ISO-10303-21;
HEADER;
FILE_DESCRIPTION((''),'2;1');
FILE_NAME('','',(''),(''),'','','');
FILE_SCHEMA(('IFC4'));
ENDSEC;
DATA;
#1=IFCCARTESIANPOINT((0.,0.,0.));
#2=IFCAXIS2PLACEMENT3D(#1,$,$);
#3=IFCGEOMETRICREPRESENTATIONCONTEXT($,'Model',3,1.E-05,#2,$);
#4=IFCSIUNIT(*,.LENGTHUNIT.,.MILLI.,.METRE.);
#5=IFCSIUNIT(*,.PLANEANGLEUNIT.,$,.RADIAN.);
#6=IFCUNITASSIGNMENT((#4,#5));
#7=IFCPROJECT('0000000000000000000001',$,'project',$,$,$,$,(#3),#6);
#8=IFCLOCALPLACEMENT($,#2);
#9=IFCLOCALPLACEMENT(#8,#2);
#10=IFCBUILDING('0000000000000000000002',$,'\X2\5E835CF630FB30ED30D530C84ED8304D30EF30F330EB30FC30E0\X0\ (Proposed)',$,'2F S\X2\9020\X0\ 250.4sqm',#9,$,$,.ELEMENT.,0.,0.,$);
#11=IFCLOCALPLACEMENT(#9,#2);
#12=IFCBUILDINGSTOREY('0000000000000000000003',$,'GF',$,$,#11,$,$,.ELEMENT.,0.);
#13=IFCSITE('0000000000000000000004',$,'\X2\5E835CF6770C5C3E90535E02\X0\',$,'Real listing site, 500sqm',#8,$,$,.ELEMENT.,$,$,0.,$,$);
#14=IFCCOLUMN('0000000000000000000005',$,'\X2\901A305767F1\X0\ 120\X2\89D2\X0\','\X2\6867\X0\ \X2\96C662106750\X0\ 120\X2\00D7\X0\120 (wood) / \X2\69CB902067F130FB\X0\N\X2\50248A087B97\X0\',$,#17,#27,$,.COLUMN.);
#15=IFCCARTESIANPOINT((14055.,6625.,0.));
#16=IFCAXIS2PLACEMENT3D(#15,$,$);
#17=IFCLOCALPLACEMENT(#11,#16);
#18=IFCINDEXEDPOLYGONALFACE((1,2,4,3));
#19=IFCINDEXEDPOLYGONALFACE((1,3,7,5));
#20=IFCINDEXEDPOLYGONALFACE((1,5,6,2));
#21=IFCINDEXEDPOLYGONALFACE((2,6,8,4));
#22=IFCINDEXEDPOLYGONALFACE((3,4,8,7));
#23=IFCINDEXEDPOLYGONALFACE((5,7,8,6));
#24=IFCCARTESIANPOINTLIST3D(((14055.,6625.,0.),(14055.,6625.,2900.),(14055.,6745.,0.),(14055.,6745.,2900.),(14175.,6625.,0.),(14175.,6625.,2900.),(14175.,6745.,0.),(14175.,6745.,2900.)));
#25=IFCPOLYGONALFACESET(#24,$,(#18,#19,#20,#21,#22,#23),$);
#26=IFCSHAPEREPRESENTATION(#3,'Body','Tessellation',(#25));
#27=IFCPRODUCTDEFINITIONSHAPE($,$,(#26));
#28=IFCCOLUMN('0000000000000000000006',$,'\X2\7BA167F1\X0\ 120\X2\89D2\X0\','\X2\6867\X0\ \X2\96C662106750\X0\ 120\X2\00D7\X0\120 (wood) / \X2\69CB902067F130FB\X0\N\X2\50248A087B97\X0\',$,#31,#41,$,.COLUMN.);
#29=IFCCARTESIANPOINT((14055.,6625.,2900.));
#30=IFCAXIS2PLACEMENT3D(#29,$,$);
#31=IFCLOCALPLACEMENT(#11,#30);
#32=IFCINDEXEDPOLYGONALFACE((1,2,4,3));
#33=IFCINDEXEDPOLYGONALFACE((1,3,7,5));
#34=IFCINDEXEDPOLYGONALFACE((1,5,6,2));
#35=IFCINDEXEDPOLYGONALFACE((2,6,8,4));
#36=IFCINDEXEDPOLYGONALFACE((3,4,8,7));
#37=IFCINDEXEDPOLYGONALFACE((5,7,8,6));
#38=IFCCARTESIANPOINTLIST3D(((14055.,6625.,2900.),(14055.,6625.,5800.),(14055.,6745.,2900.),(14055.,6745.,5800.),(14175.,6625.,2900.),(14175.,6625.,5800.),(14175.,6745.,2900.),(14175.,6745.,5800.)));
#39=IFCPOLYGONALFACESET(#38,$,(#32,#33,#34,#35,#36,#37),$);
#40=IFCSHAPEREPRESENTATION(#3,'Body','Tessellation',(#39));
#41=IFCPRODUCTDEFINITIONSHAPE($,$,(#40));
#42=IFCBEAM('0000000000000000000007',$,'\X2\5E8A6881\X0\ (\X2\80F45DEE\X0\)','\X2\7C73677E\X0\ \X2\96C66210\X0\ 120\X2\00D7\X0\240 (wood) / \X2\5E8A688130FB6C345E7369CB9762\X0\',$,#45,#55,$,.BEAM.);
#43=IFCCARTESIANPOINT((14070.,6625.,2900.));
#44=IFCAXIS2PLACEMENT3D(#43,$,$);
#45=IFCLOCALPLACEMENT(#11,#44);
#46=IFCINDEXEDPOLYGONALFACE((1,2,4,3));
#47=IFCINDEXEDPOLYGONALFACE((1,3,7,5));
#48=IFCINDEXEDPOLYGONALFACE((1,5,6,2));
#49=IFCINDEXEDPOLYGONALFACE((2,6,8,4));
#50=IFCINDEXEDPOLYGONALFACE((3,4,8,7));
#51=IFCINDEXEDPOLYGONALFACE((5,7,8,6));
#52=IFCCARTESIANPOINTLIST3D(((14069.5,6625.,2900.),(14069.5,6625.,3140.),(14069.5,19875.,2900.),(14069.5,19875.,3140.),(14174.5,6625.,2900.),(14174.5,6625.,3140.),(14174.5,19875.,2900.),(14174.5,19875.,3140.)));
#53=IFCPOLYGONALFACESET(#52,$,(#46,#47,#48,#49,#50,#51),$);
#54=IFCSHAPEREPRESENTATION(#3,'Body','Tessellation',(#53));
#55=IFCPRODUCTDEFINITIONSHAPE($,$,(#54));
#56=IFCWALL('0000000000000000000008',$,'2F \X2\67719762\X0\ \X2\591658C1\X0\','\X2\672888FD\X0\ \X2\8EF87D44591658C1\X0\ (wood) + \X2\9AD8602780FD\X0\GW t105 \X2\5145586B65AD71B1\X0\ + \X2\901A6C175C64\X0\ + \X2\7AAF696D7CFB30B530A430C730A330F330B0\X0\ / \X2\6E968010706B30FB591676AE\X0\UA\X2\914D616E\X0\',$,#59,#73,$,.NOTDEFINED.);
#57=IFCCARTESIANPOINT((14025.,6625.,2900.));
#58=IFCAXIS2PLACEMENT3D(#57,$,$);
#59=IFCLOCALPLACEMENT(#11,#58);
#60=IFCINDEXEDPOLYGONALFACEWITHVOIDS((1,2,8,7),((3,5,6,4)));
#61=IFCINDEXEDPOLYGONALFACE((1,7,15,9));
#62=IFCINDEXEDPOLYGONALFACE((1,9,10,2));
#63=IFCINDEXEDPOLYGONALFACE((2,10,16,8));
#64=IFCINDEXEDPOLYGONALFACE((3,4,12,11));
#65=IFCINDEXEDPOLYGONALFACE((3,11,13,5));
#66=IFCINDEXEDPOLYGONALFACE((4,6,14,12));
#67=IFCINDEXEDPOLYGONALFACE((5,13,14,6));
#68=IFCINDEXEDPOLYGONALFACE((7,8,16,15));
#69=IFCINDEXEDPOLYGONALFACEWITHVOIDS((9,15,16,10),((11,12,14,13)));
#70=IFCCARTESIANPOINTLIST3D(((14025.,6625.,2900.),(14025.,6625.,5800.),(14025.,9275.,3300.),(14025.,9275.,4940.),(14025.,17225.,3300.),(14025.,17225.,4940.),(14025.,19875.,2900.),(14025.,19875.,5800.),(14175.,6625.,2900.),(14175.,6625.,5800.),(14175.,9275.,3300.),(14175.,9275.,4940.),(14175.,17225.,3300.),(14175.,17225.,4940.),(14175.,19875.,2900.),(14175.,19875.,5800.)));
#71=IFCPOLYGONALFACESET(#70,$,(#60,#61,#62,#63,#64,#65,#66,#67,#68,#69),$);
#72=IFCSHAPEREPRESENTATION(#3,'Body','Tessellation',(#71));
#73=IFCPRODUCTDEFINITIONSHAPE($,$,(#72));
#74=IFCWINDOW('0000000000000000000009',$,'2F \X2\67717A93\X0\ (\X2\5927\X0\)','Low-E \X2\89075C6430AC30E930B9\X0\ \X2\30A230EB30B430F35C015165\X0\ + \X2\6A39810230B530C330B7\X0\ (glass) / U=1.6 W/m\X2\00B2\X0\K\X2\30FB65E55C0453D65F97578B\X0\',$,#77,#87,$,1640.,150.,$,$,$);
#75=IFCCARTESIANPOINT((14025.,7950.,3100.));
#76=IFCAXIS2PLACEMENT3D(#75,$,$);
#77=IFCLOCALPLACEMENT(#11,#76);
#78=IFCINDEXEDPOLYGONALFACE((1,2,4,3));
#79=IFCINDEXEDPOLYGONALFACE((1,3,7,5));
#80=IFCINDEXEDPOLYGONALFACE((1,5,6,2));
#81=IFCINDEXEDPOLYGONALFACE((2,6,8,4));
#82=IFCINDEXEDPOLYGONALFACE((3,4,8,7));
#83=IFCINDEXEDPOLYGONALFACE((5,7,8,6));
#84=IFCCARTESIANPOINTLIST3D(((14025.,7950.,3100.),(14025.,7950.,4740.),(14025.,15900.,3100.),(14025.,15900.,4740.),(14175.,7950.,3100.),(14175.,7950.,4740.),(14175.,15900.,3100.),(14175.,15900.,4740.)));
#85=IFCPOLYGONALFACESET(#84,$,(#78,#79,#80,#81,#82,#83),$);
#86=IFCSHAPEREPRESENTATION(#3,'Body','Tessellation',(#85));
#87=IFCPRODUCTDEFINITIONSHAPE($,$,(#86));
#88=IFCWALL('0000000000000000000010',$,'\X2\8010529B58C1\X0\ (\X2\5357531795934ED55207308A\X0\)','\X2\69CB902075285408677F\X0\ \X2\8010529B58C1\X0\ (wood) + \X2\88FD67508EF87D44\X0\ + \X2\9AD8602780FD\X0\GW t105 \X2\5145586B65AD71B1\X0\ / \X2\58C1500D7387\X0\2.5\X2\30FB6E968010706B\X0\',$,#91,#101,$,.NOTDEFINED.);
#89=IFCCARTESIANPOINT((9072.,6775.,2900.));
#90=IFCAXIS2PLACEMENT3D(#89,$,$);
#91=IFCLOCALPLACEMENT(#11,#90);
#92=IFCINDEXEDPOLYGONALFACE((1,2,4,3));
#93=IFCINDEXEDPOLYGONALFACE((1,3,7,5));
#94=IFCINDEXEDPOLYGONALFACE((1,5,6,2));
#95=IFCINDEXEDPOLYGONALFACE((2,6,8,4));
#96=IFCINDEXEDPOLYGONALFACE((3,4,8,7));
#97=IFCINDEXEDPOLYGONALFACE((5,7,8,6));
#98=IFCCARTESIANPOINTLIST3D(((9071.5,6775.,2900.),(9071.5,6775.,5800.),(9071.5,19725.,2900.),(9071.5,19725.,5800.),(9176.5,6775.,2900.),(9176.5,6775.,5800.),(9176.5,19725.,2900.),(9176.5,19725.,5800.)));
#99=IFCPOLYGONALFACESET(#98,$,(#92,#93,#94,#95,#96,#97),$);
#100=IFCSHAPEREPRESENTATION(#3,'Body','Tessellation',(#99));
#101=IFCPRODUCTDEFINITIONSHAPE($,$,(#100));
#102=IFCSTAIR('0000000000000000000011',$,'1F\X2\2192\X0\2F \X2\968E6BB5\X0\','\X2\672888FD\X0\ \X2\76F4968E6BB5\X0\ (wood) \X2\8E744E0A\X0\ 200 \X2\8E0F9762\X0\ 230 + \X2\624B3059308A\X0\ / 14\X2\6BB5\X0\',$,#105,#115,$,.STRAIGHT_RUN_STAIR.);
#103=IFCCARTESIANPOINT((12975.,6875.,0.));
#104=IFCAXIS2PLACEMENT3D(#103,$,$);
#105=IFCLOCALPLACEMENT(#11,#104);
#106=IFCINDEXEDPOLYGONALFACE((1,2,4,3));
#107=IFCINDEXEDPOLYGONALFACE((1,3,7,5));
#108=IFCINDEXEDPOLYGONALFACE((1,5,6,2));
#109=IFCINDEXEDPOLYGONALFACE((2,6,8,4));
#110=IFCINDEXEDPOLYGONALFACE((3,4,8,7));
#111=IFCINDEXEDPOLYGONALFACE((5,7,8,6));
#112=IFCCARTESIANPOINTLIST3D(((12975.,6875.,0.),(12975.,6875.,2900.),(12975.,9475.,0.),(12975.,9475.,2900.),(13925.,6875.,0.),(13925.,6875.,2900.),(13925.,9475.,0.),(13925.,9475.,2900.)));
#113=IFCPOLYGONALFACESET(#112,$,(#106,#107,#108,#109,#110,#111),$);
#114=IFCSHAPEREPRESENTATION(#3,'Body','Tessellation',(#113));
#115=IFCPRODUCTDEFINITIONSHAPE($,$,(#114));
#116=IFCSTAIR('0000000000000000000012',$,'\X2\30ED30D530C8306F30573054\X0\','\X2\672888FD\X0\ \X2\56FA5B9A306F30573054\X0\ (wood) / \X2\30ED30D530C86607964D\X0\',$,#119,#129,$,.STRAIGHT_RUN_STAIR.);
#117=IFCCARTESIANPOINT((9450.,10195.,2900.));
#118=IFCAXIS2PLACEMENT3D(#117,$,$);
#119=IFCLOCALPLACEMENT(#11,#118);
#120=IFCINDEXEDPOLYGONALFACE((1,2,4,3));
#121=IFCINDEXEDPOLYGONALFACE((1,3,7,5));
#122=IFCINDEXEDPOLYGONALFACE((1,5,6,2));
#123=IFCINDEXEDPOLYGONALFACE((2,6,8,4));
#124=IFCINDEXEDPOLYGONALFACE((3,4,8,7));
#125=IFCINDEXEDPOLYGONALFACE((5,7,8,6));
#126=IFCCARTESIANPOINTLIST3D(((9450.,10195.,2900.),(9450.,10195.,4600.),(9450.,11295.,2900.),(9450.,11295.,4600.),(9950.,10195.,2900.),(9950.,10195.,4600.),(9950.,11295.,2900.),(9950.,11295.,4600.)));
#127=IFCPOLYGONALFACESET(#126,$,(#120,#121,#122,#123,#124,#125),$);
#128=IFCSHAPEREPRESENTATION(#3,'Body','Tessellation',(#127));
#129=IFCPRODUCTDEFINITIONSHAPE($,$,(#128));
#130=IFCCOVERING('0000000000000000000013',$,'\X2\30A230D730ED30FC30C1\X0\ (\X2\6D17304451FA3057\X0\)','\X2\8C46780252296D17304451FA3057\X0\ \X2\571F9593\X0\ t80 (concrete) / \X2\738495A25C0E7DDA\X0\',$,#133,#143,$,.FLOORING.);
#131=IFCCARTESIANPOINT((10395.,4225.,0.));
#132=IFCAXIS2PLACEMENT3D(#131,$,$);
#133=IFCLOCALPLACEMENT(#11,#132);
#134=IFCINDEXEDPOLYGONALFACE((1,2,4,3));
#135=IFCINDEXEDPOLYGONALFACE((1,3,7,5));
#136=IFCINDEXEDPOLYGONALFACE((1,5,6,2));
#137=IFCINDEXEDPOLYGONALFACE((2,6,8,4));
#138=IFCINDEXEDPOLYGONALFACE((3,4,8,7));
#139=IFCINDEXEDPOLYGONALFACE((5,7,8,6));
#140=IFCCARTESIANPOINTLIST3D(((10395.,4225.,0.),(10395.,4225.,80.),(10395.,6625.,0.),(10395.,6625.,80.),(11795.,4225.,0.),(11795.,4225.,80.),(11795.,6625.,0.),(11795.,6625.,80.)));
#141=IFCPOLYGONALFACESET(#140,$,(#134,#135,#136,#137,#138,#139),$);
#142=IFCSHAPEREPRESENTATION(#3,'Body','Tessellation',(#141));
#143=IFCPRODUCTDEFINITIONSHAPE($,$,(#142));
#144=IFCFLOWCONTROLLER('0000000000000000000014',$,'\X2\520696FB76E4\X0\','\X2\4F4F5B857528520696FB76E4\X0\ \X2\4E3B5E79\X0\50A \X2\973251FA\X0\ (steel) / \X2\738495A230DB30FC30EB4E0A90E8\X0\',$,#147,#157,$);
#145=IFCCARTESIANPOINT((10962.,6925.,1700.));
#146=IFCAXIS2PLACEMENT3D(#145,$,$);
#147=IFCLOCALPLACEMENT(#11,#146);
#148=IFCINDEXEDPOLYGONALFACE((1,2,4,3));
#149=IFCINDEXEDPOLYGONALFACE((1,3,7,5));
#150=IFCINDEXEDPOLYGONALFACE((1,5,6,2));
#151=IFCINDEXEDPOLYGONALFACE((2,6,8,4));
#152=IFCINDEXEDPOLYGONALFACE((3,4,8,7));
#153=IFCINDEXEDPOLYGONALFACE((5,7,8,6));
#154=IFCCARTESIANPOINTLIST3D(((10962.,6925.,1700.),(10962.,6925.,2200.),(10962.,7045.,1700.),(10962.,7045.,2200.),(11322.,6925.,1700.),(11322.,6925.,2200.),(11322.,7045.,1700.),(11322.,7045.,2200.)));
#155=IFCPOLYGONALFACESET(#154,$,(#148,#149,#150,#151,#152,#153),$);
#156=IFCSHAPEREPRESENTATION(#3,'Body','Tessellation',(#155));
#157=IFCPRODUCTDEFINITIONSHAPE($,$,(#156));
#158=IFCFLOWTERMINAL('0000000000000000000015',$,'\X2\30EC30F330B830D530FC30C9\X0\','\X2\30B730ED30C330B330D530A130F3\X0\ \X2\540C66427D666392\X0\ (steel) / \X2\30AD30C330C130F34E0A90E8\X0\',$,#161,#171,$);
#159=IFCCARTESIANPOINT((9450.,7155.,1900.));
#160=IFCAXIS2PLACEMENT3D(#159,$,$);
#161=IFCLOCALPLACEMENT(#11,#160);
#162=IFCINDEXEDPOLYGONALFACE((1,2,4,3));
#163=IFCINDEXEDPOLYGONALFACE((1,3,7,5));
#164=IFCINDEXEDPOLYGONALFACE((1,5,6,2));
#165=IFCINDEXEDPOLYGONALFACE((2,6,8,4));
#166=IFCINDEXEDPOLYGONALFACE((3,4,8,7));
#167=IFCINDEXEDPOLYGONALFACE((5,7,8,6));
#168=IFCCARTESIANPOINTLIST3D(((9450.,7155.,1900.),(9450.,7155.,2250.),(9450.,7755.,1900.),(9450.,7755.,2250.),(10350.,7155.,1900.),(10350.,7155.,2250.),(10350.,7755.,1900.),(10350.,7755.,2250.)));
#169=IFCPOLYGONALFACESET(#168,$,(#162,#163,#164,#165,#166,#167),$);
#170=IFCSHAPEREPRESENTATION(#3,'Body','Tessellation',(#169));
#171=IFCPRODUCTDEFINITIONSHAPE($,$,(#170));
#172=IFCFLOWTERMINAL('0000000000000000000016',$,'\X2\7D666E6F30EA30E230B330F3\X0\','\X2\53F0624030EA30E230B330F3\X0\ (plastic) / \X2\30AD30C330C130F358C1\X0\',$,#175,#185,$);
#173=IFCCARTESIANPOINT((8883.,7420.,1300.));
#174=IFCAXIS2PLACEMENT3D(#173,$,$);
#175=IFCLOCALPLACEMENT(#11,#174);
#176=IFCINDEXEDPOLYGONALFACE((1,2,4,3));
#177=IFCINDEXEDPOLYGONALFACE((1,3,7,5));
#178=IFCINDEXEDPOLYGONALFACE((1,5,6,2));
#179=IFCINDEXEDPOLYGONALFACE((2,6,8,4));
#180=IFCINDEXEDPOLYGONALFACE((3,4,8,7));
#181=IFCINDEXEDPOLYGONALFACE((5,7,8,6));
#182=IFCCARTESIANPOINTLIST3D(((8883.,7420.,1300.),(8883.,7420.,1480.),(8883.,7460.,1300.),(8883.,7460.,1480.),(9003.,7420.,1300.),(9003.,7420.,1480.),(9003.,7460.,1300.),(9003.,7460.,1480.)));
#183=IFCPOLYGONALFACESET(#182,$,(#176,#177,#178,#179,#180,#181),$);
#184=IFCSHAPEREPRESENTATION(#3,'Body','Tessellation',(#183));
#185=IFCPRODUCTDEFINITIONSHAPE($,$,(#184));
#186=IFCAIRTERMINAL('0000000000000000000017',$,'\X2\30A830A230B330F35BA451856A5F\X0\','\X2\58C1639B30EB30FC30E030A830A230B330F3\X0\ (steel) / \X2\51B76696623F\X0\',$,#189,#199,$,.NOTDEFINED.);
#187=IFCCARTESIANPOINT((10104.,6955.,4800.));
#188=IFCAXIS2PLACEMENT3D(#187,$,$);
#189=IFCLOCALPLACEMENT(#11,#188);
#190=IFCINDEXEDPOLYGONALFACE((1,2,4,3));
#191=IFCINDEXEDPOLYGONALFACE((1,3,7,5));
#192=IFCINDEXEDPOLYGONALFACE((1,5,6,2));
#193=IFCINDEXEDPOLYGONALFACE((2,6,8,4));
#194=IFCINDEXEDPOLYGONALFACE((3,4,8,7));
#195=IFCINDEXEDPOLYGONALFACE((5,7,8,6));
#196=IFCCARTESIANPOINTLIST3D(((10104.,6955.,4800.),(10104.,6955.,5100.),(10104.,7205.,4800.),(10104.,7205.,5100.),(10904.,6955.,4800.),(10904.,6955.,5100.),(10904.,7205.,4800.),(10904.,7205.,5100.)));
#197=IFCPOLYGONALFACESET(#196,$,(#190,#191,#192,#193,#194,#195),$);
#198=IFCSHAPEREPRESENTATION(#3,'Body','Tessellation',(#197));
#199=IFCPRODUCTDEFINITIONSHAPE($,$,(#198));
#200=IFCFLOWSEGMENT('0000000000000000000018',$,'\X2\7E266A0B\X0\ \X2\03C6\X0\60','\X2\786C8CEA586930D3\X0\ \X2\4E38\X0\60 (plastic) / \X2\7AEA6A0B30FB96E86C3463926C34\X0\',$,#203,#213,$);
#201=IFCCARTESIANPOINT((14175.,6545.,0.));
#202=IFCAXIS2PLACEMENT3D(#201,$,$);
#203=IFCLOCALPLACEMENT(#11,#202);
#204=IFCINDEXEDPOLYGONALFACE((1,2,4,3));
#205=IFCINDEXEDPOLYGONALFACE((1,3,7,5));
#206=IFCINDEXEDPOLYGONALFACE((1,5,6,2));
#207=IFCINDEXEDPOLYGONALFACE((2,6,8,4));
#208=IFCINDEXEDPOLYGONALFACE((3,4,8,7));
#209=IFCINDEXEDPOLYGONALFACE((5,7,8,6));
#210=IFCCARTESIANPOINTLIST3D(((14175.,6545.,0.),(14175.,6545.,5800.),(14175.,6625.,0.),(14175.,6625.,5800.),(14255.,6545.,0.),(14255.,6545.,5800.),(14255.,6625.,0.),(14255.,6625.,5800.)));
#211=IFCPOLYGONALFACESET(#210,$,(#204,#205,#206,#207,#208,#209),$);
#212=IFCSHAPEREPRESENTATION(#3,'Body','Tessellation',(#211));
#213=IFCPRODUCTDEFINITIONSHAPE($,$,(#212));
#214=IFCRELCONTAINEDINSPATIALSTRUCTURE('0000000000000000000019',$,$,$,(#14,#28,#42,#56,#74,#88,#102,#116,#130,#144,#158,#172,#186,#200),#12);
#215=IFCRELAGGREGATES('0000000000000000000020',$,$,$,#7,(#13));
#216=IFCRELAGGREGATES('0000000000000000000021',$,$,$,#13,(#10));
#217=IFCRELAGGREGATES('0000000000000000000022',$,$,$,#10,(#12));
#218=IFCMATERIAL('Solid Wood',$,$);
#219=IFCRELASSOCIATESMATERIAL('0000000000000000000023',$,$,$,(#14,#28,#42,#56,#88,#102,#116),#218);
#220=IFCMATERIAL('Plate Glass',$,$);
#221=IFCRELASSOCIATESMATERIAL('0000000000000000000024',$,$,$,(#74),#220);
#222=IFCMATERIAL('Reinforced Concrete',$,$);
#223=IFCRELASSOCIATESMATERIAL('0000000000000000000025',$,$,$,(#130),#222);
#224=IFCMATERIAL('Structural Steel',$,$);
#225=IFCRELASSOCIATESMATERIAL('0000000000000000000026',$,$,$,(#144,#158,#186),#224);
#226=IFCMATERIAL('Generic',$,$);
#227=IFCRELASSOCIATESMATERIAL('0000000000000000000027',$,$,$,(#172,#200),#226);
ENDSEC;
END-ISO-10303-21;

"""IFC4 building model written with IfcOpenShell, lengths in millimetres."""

from ifc_helpers import new_model, si_unit, frame, frame_2d, origin, place, context, project, spatial, rectangle, extrude, material, element, fill, save


model = new_model("IFC4")

# Units and contexts
model_context = context("Model", 3, precision=1e-05, world=origin())
ifc_project = project(units=[si_unit("LENGTHUNIT", "METRE", prefix="MILLI"), si_unit("PLANEANGLEUNIT", "RADIAN")], contexts=[model_context])

# Site, building, storey
site_placement = place(None, origin())
site = spatial("IfcSite", under=ifc_project, at=site_placement, Name="広島県尾道市", ObjectType="Real listing site, 500sqm", CompositionType="ELEMENT", RefElevation=0.0)
building_placement = place(site_placement, origin())
building = spatial("IfcBuilding", under=site, at=building_placement, Name="広島・ロフト付きワンルーム (Proposed)", ObjectType="2F S造 250.4sqm", CompositionType="ELEMENT", ElevationOfRefHeight=0.0, ElevationOfTerrain=0.0)
storey_placement = place(building_placement, origin())
storey = spatial("IfcBuildingStorey", under=building, at=storey_placement, Name="GF", CompositionType="ELEMENT", Elevation=0.0)

# Columns
ifc_material_1 = material(Name="Solid Wood")
column_1_placement = place(storey_placement, frame((14055.0, 6625.0, 0.0)))
element("IfcColumn", 1, at=column_1_placement, inside=storey, material=ifc_material_1, Name="通し柱 120角", Description="桧 集成材 120×120 (wood) / 構造柱・N値計算", PredefinedType="COLUMN", context=model_context, shape_type="SweptSolid", body=[
    extrude(rectangle(XDim=120.0, YDim=120.0, at=frame_2d((60.0, 60.0))), frame((14055.0, 6625.0, 0.0)), (0.0, 0.0, 1.0), 2900.0),
])
column_2_placement = place(storey_placement, frame((14055.0, 6625.0, 2900.0)))
element("IfcColumn", 2, at=column_2_placement, inside=storey, material=ifc_material_1, Name="管柱 120角", Description="桧 集成材 120×120 (wood) / 構造柱・N値計算", PredefinedType="COLUMN", context=model_context, shape_type="SweptSolid", body=[
    extrude(rectangle(XDim=120.0, YDim=120.0, at=frame_2d((60.0, 60.0))), frame((14055.0, 6625.0, 2900.0)), (0.0, 0.0, 1.0), 2900.0),
])

# Beam
beam_1_placement = place(storey_placement, frame((14070.0, 6625.0, 2900.0)))
element("IfcBeam", 3, at=beam_1_placement, inside=storey, material=ifc_material_1, Name="床梁 (胴差)", Description="米松 集成 120×240 (wood) / 床梁・水平構面", PredefinedType="BEAM", context=model_context, shape_type="SweptSolid", body=[
    extrude(rectangle(XDim=105.0, YDim=13250.0, at=frame_2d((52.0, 6625.0))), frame((14070.0, 6625.0, 2900.0)), (0.0, 0.0, 1.0), 240.0),
])

# Shared definitions
ifc_material_2 = material(Name="Plate Glass")

# Wall, opening, window
wall_1_placement = place(storey_placement, frame((14025.0, 6625.0, 2900.0)))
wall_1 = element("IfcWall", 4, at=wall_1_placement, inside=storey, material=ifc_material_1, Name="2F 東面 外壁", Description="木製 軸組外壁 (wood) + 高性能GW t105 充填断熱 + 通気層 + 窯業系サイディング / 準耐火・外皮UA配慮", PredefinedType="NOTDEFINED", context=model_context, shape_type="SweptSolid", body=[
    extrude(rectangle(XDim=150.0, YDim=13250.0, at=frame_2d((75.0, 6625.0))), frame((14025.0, 6625.0, 2900.0)), (0.0, 0.0, 1.0), 2900.0),
])
opening_1_placement = place(storey_placement, frame((14025.0, 7950.0, 3100.0)))
opening_1 = element("IfcOpeningElement", 5, at=opening_1_placement, cuts=wall_1, PredefinedType="NOTDEFINED", context=model_context, shape_type="SweptSolid", body=[
    extrude(rectangle(XDim=150.0, YDim=7950.0, at=frame_2d((75.0, 3975.0))), frame((14025.0, 7950.0, 3100.0)), (0.0, 0.0, 1.0), 1640.0),
])
window_1_placement = place(storey_placement, frame((14025.0, 7950.0, 3100.0)))
window_1 = element("IfcWindow", 6, at=window_1_placement, inside=storey, material=ifc_material_2, Name="2F 東窓 (大)", Description="Low-E 複層ガラス アルゴン封入 + 樹脂サッシ (glass) / U=1.6 W/m²K・日射取得型", OverallHeight=1640.0, OverallWidth=150.0, context=model_context, shape_type="SweptSolid", body=[
    extrude(rectangle(XDim=150.0, YDim=7950.0, at=frame_2d((75.0, 3975.0))), frame((14025.0, 7950.0, 3100.0)), (0.0, 0.0, 1.0), 1640.0),
])
fill(opening_1, window_1)

# Wall
wall_2_placement = place(storey_placement, frame((9072.0, 6775.0, 2900.0)))
element("IfcWall", 7, at=wall_2_placement, inside=storey, material=ifc_material_1, Name="耐力壁 (南北間仕切り)", Description="構造用合板 耐力壁 (wood) + 製材軸組 + 高性能GW t105 充填断熱 / 壁倍率2.5・準耐火", PredefinedType="NOTDEFINED", context=model_context, shape_type="SweptSolid", body=[
    extrude(rectangle(XDim=105.0, YDim=12950.0, at=frame_2d((52.0, 6475.0))), frame((9072.0, 6775.0, 2900.0)), (0.0, 0.0, 1.0), 2900.0),
])

# Stairs
stair_1_placement = place(storey_placement, frame((12975.0, 6875.0, 0.0)))
element("IfcStair", 8, at=stair_1_placement, inside=storey, material=ifc_material_1, Name="1F→2F 階段", Description="木製 直階段 (wood) 蹴上 200 踏面 230 + 手すり / 14段", PredefinedType="STRAIGHT_RUN_STAIR", context=model_context, shape_type="SweptSolid", body=[
    extrude(rectangle(XDim=950.0, YDim=2600.0, at=frame_2d((475.0, 1300.0))), frame((12975.0, 6875.0, 0.0)), (0.0, 0.0, 1.0), 2900.0),
])
stair_2_placement = place(storey_placement, frame((9450.0, 10195.0, 2900.0)))
element("IfcStair", 9, at=stair_2_placement, inside=storey, material=ifc_material_1, Name="ロフトはしご", Description="木製 固定はしご (wood) / ロフト昇降", PredefinedType="STRAIGHT_RUN_STAIR", context=model_context, shape_type="SweptSolid", body=[
    extrude(rectangle(XDim=500.0, YDim=1100.0, at=frame_2d((250.0, 550.0))), frame((9450.0, 10195.0, 2900.0)), (0.0, 0.0, 1.0), 1700.0),
])

# Covering
ifc_material_3 = material(Name="Reinforced Concrete")
covering_placement = place(storey_placement, frame((10395.0, 4225.0, 0.0)))
element("IfcCovering", 10, at=covering_placement, inside=storey, material=ifc_material_3, Name="アプローチ (洗い出し)", Description="豆砂利洗い出し 土間 t80 (concrete) / 玄関導線", PredefinedType="FLOORING", context=model_context, shape_type="SweptSolid", body=[
    extrude(rectangle(XDim=1400.0, YDim=2400.0, at=frame_2d((700.0, 1200.0))), frame((10395.0, 4225.0, 0.0)), (0.0, 0.0, 1.0), 80.0),
])

# Flow controller
ifc_material_4 = material(Name="Structural Steel")
flow_controller_placement = place(storey_placement, frame((10962.0, 6925.0, 1700.0)))
element("IfcFlowController", 11, at=flow_controller_placement, inside=storey, material=ifc_material_4, Name="分電盤", Description="住宅用分電盤 主幹50A 露出 (steel) / 玄関ホール上部", context=model_context, shape_type="SweptSolid", body=[
    extrude(rectangle(XDim=360.0, YDim=120.0, at=frame_2d((180.0, 60.0))), frame((10962.0, 6925.0, 1700.0)), (0.0, 0.0, 1.0), 500.0),
])

# Flow terminals
flow_terminal_1_placement = place(storey_placement, frame((9450.0, 7155.0, 1900.0)))
element("IfcFlowTerminal", 12, at=flow_terminal_1_placement, inside=storey, material=ifc_material_4, Name="レンジフード", Description="シロッコファン 同時給排 (steel) / キッチン上部", context=model_context, shape_type="SweptSolid", body=[
    extrude(rectangle(XDim=900.0, YDim=600.0, at=frame_2d((450.0, 300.0))), frame((9450.0, 7155.0, 1900.0)), (0.0, 0.0, 1.0), 350.0),
])
ifc_material_5 = material(Name="Generic")
flow_terminal_2_placement = place(storey_placement, frame((8883.0, 7420.0, 1300.0)))
element("IfcFlowTerminal", 13, at=flow_terminal_2_placement, inside=storey, material=ifc_material_5, Name="給湯リモコン", Description="台所リモコン (plastic) / キッチン壁", context=model_context, shape_type="SweptSolid", body=[
    extrude(rectangle(XDim=120.0, YDim=40.0, at=frame_2d((60.0, 20.0))), frame((8883.0, 7420.0, 1300.0)), (0.0, 0.0, 1.0), 180.0),
])

# Air terminal
air_terminal_placement = place(storey_placement, frame((10104.0, 6955.0, 4800.0)))
element("IfcAirTerminal", 14, at=air_terminal_placement, inside=storey, material=ifc_material_4, Name="エアコン室内機", Description="壁掛ルームエアコン (steel) / 冷暖房", PredefinedType="NOTDEFINED", context=model_context, shape_type="SweptSolid", body=[
    extrude(rectangle(XDim=800.0, YDim=250.0, at=frame_2d((400.0, 125.0))), frame((10104.0, 6955.0, 4800.0)), (0.0, 0.0, 1.0), 300.0),
])

# Flow segment
flow_segment_placement = place(storey_placement, frame((14175.0, 6545.0, 0.0)))
element("IfcFlowSegment", 15, at=flow_segment_placement, inside=storey, material=ifc_material_5, Name="縦樋 φ60", Description="硬質塩ビ 丸60 (plastic) / 竪樋・雨水排水", context=model_context, shape_type="SweptSolid", body=[
    extrude(rectangle(XDim=80.0, YDim=80.0, at=frame_2d((40.0, 40.0))), frame((14175.0, 6545.0, 0.0)), (0.0, 0.0, 1.0), 5800.0),
])

save(model, "model.ifc")
